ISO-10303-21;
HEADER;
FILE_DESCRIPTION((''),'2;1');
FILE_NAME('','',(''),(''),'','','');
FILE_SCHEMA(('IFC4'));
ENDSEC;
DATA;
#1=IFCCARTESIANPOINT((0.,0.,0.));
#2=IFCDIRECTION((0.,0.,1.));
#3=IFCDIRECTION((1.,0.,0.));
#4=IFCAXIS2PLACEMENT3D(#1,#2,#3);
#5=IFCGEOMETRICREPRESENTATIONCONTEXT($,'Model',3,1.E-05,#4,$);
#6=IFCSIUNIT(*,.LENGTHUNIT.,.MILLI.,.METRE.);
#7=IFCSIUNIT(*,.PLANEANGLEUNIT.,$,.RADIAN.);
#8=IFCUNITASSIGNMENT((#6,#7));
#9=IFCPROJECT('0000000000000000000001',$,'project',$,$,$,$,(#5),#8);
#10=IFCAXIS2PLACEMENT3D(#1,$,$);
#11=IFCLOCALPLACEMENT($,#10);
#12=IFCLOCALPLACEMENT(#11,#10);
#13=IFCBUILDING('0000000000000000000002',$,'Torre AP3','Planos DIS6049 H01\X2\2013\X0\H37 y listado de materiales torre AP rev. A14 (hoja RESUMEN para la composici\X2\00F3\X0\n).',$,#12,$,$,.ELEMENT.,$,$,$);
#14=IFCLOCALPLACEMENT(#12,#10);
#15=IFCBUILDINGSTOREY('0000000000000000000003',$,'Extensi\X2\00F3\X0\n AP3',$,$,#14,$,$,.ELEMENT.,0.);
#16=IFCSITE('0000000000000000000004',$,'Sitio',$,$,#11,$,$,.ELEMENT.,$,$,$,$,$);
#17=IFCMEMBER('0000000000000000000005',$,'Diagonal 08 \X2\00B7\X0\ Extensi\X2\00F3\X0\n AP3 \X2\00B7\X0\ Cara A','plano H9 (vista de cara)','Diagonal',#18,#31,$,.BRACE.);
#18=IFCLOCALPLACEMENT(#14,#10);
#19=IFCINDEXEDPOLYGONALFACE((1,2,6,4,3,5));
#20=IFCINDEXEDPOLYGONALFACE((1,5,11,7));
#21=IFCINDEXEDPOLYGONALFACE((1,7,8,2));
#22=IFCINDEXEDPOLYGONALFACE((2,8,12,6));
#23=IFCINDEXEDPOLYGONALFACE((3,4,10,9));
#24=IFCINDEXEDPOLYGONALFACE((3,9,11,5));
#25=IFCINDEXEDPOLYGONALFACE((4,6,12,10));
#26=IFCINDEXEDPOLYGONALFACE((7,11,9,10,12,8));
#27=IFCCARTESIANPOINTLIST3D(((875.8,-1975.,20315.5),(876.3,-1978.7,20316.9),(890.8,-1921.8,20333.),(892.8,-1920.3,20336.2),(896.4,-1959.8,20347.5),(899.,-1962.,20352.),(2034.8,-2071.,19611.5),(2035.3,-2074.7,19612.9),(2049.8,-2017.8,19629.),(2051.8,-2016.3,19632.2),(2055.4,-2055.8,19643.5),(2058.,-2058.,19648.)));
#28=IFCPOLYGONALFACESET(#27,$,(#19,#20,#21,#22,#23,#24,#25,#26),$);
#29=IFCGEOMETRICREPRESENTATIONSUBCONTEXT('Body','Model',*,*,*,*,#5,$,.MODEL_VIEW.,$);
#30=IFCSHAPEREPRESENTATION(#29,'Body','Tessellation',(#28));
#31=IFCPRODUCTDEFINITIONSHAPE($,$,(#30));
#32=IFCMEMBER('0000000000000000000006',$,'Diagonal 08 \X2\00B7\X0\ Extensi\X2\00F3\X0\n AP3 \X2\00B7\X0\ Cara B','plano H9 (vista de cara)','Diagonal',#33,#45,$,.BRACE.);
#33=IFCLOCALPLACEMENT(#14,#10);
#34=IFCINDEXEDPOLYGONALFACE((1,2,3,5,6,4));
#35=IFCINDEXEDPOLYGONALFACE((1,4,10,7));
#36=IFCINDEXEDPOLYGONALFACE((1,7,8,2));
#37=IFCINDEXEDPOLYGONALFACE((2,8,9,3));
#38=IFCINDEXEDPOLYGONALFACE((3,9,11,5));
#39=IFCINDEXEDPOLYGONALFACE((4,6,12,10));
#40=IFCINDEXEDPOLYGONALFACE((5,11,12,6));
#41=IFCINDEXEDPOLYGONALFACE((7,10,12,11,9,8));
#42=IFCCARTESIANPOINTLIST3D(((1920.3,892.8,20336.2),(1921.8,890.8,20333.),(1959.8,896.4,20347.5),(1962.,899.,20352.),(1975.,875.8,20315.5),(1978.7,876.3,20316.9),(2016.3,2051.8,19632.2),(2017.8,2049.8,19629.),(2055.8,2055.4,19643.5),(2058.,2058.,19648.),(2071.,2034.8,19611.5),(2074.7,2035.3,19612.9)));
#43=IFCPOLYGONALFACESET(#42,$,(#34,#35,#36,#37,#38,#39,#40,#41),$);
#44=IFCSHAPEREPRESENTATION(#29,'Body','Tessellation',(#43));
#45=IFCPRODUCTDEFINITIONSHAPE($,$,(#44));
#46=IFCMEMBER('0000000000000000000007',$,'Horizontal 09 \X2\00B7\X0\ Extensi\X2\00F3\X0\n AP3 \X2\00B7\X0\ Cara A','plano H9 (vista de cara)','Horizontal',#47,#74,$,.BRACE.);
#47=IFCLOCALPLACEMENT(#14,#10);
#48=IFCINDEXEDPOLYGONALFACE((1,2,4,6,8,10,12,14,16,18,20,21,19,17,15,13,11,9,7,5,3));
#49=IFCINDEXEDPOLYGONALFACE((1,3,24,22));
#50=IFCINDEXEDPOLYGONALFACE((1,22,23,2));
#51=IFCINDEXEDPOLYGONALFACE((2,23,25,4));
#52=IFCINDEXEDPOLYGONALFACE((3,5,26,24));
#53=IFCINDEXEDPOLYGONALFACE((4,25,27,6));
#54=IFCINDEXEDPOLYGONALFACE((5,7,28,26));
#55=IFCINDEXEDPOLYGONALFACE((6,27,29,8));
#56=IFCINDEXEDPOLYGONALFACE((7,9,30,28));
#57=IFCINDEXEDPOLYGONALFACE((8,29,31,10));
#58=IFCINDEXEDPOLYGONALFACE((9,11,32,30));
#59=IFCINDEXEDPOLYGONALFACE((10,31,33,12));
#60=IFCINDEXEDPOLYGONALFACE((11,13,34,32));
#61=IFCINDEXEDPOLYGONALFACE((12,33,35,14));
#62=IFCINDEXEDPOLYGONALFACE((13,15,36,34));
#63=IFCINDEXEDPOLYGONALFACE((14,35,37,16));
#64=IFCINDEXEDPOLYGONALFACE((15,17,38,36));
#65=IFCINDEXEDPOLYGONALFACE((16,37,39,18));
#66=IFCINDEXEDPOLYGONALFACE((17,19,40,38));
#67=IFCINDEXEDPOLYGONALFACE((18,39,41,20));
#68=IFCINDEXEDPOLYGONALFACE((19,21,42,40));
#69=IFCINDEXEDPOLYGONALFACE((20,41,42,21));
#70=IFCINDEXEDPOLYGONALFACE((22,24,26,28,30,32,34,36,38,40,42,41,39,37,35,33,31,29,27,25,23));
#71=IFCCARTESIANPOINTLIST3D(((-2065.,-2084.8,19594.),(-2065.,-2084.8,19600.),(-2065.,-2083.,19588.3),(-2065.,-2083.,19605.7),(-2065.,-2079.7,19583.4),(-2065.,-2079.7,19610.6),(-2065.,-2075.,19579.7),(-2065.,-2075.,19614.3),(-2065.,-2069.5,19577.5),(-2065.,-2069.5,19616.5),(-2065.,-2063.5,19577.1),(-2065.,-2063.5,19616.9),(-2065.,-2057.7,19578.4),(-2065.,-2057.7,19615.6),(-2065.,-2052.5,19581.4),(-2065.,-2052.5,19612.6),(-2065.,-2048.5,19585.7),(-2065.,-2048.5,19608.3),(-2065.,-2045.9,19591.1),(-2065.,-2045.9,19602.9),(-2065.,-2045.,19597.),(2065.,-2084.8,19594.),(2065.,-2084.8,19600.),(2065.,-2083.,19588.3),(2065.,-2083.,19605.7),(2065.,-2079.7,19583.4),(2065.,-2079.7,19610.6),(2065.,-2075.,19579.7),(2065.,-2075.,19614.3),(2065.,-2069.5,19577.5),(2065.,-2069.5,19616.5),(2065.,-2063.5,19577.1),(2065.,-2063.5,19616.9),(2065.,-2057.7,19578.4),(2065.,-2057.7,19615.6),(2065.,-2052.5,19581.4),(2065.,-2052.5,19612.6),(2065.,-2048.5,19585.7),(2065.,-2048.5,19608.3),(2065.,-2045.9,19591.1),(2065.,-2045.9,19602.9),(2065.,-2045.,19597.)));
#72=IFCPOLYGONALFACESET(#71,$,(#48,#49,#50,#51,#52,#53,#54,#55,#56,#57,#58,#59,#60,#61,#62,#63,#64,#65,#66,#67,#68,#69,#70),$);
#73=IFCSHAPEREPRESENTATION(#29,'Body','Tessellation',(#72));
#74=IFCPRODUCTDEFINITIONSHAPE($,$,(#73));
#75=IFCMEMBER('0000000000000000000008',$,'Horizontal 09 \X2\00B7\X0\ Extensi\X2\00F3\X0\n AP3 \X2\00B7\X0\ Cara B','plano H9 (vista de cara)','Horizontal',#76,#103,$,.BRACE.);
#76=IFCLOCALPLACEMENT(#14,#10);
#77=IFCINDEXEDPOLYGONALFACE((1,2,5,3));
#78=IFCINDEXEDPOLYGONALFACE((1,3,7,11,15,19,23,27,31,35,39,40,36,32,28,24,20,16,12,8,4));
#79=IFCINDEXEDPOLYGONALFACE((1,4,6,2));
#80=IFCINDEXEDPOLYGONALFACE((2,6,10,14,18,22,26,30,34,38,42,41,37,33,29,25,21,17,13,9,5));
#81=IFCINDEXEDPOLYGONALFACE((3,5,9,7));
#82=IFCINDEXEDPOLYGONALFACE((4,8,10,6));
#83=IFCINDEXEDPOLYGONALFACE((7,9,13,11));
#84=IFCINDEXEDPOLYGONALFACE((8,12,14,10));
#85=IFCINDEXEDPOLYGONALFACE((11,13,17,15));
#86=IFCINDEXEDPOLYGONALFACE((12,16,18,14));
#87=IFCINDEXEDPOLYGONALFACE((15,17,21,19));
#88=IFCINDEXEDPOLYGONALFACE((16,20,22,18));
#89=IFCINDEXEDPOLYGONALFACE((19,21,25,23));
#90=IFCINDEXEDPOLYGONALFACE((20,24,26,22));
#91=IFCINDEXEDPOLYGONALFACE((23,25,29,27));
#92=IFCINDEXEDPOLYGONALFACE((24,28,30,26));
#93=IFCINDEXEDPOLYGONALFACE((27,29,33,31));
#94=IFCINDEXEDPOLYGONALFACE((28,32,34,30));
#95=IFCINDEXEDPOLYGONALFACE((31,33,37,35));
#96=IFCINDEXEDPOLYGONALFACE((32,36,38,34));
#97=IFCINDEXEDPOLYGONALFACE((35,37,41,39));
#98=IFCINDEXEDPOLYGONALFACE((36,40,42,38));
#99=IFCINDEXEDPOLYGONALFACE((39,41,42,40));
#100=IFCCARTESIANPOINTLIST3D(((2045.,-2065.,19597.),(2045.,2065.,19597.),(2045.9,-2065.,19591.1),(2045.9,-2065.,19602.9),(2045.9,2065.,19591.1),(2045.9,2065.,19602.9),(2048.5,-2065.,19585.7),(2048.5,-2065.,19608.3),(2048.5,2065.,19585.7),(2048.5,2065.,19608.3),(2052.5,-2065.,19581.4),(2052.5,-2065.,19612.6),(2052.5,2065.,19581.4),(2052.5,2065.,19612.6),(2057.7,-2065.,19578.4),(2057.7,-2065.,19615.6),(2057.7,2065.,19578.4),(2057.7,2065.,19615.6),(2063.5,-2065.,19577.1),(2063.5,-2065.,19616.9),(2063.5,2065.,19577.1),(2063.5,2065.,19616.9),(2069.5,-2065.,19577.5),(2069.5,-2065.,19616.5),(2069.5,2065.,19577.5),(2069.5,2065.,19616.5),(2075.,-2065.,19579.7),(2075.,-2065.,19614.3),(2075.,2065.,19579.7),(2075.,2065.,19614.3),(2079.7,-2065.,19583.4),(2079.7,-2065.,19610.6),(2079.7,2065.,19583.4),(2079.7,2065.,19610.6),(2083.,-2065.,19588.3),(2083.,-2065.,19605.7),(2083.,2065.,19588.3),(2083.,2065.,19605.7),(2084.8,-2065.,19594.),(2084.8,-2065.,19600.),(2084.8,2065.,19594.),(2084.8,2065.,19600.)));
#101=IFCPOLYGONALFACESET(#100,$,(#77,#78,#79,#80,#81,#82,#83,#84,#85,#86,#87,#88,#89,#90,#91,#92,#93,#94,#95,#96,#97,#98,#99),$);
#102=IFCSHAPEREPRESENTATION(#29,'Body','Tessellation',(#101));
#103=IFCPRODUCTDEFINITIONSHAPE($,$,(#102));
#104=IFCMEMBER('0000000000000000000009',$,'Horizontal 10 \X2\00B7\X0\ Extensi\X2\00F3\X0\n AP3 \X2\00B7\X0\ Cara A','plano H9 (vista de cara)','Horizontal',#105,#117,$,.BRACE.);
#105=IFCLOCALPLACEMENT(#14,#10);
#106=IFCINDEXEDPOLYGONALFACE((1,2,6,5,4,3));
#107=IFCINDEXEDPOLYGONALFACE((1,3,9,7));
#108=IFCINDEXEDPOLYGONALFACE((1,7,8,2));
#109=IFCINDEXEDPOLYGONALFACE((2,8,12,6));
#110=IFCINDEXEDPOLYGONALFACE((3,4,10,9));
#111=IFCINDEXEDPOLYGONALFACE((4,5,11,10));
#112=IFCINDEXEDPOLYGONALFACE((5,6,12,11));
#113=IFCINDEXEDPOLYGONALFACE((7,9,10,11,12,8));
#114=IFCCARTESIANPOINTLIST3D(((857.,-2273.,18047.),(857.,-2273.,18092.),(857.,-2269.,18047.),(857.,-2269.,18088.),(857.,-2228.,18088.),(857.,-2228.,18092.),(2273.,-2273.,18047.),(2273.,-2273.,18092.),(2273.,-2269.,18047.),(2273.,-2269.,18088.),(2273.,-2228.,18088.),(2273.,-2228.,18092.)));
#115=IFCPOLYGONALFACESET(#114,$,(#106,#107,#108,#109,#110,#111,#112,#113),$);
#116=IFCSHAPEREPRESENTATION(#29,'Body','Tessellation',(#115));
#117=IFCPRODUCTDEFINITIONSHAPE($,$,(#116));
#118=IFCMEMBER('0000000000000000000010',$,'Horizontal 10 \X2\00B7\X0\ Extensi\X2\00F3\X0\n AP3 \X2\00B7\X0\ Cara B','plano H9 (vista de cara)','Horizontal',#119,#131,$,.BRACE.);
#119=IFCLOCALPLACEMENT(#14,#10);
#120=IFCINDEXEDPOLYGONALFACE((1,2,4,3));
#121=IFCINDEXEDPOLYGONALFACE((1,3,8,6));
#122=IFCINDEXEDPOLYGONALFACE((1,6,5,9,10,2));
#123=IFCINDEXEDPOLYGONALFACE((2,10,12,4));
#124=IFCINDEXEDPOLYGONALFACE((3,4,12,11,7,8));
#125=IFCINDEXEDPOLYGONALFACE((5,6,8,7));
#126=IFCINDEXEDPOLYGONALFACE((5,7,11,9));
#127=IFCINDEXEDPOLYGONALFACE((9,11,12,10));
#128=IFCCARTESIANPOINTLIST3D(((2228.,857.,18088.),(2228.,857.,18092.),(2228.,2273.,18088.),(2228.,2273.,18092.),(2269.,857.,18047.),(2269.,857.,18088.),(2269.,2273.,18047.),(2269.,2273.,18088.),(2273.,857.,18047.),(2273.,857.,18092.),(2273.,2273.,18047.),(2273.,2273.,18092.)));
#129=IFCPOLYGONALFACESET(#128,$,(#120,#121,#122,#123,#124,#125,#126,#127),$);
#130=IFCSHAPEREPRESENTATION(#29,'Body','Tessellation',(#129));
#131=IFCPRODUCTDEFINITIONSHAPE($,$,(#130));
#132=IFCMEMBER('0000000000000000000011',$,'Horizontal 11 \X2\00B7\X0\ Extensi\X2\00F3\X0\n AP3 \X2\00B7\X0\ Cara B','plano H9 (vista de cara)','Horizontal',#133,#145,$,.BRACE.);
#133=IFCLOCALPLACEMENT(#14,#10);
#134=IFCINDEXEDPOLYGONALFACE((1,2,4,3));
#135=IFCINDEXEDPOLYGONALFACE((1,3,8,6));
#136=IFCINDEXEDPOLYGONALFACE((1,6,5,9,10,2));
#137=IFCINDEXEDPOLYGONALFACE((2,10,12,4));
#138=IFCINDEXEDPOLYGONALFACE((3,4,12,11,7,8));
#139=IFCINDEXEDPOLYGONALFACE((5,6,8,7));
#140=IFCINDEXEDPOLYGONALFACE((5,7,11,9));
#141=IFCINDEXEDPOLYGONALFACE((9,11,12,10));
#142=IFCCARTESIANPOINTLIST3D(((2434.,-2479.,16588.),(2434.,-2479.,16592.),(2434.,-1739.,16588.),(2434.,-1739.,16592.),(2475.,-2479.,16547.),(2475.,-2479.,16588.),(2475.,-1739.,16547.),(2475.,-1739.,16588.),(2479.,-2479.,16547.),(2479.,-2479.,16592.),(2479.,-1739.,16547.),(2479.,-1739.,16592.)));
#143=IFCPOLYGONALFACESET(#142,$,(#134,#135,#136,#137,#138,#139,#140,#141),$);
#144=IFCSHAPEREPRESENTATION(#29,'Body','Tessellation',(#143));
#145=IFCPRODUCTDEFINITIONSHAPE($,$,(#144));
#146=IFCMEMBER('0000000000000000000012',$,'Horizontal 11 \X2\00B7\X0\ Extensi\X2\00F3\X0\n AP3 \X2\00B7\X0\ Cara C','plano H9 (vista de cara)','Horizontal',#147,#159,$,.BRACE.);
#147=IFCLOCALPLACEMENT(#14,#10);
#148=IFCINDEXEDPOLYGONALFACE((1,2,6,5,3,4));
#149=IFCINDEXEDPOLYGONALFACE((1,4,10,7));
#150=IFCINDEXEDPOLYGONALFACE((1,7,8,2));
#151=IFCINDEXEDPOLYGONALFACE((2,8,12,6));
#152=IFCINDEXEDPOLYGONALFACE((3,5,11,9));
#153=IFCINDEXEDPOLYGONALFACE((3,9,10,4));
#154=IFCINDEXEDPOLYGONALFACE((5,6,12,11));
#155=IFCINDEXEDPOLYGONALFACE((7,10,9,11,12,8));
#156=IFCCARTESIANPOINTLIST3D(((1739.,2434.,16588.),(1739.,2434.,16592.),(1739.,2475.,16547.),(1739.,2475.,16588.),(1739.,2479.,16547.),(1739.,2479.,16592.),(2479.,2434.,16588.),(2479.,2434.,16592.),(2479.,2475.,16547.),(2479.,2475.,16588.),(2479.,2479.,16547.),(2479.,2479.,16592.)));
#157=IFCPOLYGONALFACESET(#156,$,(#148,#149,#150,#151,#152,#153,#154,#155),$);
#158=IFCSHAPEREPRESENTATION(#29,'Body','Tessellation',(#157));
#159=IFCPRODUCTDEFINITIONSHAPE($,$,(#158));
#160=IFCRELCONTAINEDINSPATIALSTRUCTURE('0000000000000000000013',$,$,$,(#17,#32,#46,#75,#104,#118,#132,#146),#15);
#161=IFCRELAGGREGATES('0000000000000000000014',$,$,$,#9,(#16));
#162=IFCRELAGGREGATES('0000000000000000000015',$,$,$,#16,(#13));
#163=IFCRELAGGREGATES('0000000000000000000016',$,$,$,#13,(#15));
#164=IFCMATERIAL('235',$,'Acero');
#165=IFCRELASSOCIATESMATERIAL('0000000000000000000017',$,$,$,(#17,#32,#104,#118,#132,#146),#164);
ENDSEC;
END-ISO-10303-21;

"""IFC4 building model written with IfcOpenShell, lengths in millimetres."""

from ifc_helpers import new_model, si_unit, frame, frame_2d, origin, origin_with_axes, place, context, subcontext, project, spatial, circle, l_section, extrude, material, element, save


model = new_model("IFC4")

# Units and contexts
model_context = context("Model", 3, precision=1e-05, world=origin_with_axes())
body_context = subcontext(model_context, "Body", "Model", "MODEL_VIEW")
ifc_project = project(units=[si_unit("LENGTHUNIT", "METRE", prefix="MILLI"), si_unit("PLANEANGLEUNIT", "RADIAN")], contexts=[model_context])

# Site, building, storey
site_placement = place(None, origin())
site = spatial("IfcSite", under=ifc_project, at=site_placement, Name="Sitio", CompositionType="ELEMENT")
building_placement = place(site_placement, origin())
building = spatial("IfcBuilding", under=site, at=building_placement, Name="Torre AP3", Description="Planos DIS6049 H01–H37 y listado de materiales torre AP rev. A14 (hoja RESUMEN para la composición).", CompositionType="ELEMENT")
storey_placement = place(building_placement, origin())
storey = spatial("IfcBuildingStorey", under=building, at=storey_placement, Name="Extensión AP3", CompositionType="ELEMENT", Elevation=0.0)

# Members
ifc_material_1 = material(Name="235", Category="Acero")
for number, where, z_axis, x_axis, name in (
    (1, (2058.0, -2058.0, 19648.0), (-0.852549, 0.070617, 0.517855), (-0.137057, 0.925948, -0.351904), "Diagonal 08 · Extensión AP3 · Cara A"),
    (2, (2058.0, 2058.0, 19648.0), (-0.070617, -0.852549, 0.517855), (-0.925948, -0.137057, -0.351904), "Diagonal 08 · Extensión AP3 · Cara B"),
):
    element("IfcMember", number, at=place(storey_placement, frame(where, z_axis=z_axis, x_axis=x_axis)), inside=storey, material=ifc_material_1, Name=name, Description="plano H9 (vista de cara)", ObjectType="Diagonal", PredefinedType="BRACE", context=body_context, shape_type="SweptSolid", body=[
        extrude(l_section(Depth=45.0, Width=45.0, Thickness=4.0, at=frame_2d((22.5, 22.5))), None, (0.0, 0.0, 1.0), 1359.5),
    ])
for number, where, z_axis, x_axis, name in (
    (3, (2065.0, -2065.0, 19597.0), (-1.0, 0.0, 0.0), (0.0, 1.0, 0.0), "Horizontal 09 · Extensión AP3 · Cara A"),
    (4, (2065.0, 2065.0, 19597.0), (0.0, -1.0, 0.0), (-1.0, 0.0, 0.0), "Horizontal 09 · Extensión AP3 · Cara B"),
):
    element("IfcMember", number, at=place(storey_placement, frame(where, z_axis=z_axis, x_axis=x_axis)), inside=storey, Name=name, Description="plano H9 (vista de cara)", ObjectType="Horizontal", PredefinedType="BRACE", context=body_context, shape_type="SweptSolid", body=[
        extrude(circle(Radius=20.0), None, (0.0, 0.0, 1.0), 4130.0),
    ])
for number, where, z_axis, x_axis, name in (
    (5, (2273.0, -2273.0, 18092.0), (-1.0, 0.0, 0.0), (0.0, 1.0, 0.0), "Horizontal 10 · Extensión AP3 · Cara A"),
    (6, (2273.0, 2273.0, 18092.0), (0.0, -1.0, 0.0), (-1.0, 0.0, 0.0), "Horizontal 10 · Extensión AP3 · Cara B"),
):
    element("IfcMember", number, at=place(storey_placement, frame(where, z_axis=z_axis, x_axis=x_axis)), inside=storey, material=ifc_material_1, Name=name, Description="plano H9 (vista de cara)", ObjectType="Horizontal", PredefinedType="BRACE", context=body_context, shape_type="SweptSolid", body=[
        extrude(l_section(Depth=45.0, Width=45.0, Thickness=4.0, at=frame_2d((22.5, 22.5))), None, (0.0, 0.0, 1.0), 1416.0),
    ])
for number, where, z_axis, x_axis, name in (
    (7, (2479.0, -1739.0, 16592.0), (0.0, -1.0, 0.0), (-1.0, 0.0, 0.0), "Horizontal 11 · Extensión AP3 · Cara B"),
    (8, (1739.0, 2479.0, 16592.0), (1.0, 0.0, 0.0), (0.0, -1.0, 0.0), "Horizontal 11 · Extensión AP3 · Cara C"),
):
    element("IfcMember", number, at=place(storey_placement, frame(where, z_axis=z_axis, x_axis=x_axis)), inside=storey, material=ifc_material_1, Name=name, Description="plano H9 (vista de cara)", ObjectType="Horizontal", PredefinedType="BRACE", context=body_context, shape_type="SweptSolid", body=[
        extrude(l_section(Depth=45.0, Width=45.0, Thickness=4.0, at=frame_2d((22.5, 22.5))), None, (0.0, 0.0, 1.0), 740.0),
    ])

save(model, "model.ifc")
